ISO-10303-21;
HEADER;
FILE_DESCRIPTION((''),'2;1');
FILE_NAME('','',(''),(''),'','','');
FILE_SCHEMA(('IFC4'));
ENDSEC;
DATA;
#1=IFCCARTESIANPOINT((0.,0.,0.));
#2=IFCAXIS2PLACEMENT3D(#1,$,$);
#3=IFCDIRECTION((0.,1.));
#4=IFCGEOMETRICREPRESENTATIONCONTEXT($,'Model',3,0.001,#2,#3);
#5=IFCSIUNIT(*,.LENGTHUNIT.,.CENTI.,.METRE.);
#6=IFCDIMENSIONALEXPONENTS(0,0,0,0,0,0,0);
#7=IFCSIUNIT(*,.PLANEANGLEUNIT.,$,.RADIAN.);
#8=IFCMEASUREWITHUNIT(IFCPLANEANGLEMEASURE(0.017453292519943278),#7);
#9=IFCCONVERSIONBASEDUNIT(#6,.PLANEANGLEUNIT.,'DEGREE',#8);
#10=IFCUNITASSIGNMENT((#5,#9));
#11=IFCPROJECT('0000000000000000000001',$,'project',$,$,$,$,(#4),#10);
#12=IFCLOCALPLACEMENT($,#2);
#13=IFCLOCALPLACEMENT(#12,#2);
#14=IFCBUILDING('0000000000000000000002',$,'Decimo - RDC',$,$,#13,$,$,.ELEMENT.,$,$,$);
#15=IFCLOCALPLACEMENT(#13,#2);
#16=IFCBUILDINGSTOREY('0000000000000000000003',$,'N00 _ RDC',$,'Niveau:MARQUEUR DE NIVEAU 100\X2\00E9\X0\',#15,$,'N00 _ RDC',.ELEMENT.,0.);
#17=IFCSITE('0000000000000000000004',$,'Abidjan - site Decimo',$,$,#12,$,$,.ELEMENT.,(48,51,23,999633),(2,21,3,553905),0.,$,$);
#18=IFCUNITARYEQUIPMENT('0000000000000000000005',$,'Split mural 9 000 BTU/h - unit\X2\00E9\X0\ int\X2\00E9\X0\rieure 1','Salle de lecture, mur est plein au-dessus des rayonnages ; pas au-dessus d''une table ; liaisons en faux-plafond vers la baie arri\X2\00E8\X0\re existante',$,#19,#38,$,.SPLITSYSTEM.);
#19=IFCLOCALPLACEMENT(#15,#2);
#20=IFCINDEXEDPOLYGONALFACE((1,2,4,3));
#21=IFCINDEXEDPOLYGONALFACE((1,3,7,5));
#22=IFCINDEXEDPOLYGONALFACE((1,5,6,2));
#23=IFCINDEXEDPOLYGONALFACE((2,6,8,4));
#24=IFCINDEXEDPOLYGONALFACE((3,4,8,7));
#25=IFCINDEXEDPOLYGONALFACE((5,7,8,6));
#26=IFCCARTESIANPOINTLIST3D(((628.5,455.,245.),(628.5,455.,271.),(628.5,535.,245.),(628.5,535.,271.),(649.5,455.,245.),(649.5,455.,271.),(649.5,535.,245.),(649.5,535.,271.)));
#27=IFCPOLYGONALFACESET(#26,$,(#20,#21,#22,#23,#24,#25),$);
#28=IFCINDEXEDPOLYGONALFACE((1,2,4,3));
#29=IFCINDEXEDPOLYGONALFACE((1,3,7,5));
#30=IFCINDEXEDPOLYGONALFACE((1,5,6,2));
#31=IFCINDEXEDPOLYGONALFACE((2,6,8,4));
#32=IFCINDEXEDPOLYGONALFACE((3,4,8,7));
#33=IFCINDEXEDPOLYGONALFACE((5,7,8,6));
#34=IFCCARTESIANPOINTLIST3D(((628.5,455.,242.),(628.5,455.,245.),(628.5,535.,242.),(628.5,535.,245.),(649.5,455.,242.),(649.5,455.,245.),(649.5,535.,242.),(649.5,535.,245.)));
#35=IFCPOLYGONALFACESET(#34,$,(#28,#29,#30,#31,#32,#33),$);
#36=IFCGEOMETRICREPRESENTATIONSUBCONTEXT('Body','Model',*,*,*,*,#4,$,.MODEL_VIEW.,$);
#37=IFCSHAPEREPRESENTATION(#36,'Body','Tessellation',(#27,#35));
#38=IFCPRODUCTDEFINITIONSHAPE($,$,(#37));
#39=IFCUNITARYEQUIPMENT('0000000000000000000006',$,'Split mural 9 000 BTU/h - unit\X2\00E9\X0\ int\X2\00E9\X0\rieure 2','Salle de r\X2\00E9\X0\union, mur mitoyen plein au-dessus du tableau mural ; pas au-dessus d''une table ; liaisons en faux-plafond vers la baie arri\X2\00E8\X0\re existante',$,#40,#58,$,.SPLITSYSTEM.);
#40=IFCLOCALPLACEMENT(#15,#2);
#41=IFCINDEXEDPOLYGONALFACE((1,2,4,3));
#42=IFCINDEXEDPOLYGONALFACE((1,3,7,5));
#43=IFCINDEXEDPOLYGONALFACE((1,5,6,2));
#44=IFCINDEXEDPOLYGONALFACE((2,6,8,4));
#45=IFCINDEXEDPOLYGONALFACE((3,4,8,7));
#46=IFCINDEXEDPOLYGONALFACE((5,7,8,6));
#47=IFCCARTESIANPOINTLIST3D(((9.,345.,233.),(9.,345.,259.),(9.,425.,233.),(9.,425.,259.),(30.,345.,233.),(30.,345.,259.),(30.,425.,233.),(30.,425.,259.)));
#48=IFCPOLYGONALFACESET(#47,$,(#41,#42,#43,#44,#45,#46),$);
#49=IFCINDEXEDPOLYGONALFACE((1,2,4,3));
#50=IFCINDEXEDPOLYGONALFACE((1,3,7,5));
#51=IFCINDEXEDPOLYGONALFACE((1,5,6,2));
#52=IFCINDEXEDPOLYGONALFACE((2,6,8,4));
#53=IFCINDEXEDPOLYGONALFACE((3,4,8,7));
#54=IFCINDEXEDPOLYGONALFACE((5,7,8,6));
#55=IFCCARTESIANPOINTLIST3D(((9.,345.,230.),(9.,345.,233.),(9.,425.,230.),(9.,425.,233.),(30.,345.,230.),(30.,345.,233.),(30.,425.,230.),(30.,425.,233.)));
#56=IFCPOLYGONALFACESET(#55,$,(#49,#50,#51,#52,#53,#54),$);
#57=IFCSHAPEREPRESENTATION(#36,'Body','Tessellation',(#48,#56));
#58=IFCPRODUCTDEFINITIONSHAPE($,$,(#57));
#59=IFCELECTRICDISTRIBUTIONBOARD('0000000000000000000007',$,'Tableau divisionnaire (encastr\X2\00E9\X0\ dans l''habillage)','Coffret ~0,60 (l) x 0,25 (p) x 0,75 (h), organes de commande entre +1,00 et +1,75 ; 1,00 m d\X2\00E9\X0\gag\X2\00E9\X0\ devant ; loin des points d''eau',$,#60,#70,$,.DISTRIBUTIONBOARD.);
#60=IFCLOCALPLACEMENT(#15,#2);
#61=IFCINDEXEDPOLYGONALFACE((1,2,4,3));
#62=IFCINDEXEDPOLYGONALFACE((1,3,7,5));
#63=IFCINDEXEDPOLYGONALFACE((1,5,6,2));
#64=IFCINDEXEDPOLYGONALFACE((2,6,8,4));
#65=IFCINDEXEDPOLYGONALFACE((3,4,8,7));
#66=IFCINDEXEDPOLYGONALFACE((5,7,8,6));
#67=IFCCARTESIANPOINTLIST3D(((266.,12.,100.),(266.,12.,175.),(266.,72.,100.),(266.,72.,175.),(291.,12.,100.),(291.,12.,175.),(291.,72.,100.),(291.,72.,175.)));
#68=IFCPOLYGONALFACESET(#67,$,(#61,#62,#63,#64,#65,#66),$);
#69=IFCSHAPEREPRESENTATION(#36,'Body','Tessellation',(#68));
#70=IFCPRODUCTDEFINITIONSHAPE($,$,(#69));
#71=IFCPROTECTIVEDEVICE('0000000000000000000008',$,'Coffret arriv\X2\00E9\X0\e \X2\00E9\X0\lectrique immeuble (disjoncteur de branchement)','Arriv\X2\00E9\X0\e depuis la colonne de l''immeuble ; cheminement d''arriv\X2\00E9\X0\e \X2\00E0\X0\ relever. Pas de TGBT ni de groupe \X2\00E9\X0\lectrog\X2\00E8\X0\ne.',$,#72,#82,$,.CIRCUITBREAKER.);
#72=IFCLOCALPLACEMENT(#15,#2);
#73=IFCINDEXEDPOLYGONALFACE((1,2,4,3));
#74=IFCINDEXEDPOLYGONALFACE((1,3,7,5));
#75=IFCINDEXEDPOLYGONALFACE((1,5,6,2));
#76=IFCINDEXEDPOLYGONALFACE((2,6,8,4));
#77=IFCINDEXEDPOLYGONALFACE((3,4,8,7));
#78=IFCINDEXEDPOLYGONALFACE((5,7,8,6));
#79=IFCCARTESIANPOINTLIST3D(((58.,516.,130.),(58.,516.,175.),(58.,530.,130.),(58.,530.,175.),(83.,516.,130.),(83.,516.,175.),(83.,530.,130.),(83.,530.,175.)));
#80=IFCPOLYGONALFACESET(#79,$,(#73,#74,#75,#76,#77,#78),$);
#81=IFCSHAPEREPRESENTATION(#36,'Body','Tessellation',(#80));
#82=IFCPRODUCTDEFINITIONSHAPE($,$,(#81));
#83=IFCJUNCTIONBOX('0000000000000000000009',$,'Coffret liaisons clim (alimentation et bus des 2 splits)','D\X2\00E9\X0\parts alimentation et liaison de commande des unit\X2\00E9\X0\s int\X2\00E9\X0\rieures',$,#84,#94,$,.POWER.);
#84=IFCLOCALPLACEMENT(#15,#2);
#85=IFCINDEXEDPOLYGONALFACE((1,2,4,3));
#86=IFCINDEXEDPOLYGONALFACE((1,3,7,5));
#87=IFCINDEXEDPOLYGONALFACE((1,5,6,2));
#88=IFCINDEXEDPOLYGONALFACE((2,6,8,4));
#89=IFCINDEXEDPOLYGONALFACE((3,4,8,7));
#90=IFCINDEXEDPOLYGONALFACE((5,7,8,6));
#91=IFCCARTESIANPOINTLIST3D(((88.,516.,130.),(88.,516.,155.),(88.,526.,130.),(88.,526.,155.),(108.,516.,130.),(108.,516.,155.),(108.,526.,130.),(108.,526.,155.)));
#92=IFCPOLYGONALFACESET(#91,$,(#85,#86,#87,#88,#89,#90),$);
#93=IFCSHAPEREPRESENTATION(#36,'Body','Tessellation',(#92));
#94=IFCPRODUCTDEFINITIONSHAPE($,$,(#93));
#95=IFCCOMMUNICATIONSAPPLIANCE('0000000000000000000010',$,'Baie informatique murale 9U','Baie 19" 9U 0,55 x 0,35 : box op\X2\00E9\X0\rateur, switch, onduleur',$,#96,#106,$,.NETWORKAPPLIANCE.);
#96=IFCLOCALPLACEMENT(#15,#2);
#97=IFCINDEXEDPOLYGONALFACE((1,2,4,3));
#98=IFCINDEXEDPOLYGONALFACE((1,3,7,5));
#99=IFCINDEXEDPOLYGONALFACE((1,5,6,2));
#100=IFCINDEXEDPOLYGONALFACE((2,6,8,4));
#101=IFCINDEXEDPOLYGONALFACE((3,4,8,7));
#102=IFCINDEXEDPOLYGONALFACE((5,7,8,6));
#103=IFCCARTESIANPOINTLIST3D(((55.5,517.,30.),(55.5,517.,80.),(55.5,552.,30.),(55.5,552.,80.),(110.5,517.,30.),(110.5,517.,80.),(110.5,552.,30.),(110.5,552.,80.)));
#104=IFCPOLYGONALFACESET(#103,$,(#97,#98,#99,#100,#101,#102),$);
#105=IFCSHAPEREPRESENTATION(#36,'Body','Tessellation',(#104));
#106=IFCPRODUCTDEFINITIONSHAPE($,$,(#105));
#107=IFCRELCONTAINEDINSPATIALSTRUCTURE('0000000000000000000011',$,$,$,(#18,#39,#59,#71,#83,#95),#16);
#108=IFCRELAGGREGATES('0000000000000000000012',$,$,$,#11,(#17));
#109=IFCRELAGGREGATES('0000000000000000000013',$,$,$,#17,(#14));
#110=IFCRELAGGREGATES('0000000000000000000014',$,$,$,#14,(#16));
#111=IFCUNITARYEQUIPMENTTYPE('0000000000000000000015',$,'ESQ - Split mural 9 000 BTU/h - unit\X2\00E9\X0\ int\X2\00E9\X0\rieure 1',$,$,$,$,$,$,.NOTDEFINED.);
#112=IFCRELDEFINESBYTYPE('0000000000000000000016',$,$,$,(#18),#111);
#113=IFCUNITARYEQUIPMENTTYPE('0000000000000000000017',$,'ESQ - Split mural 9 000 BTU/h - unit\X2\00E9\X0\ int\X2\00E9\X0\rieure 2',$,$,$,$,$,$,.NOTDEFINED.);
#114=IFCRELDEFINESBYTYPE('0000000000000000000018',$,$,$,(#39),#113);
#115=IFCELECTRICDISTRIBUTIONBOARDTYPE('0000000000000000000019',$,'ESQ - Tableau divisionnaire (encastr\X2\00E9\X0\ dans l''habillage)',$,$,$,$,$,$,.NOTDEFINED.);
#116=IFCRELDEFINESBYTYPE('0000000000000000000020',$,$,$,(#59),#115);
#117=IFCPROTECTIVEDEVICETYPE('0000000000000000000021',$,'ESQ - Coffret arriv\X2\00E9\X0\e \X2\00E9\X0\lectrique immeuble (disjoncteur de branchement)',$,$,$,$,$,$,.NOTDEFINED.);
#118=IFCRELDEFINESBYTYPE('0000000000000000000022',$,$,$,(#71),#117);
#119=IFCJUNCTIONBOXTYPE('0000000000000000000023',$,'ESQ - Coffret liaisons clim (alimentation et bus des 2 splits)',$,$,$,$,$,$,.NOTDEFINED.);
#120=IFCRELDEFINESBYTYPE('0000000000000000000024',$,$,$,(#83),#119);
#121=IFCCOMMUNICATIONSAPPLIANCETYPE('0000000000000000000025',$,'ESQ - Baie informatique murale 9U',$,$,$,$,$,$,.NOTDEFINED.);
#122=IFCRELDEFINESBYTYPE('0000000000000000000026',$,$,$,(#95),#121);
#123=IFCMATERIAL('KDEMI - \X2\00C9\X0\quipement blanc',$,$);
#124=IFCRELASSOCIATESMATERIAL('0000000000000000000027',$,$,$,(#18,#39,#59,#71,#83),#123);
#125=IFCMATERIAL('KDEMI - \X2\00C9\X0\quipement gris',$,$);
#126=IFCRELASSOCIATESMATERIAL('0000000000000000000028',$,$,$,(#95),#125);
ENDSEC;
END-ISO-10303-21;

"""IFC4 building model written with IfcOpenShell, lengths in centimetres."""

from ifc_helpers import new_model, entity, si_unit, converted_unit, direction, frame, frame_2d, origin, origin_with_axes, place, context, subcontext, project, spatial, rectangle, extrude, material, type_object, element, save


model = new_model("IFC4")

# Units and contexts
model_context = context("Model", 3, precision=0.001, world=origin(), true_north=direction((0.0, 1.0)))
body_context = subcontext(model_context, "Body", "Model", "MODEL_VIEW")
ifc_project = project(units=[si_unit("LENGTHUNIT", "METRE", prefix="CENTI"), converted_unit("PLANEANGLEUNIT", "DEGREE", entity("IfcPlaneAngleMeasure", 0.017453292519943278), si_unit("PLANEANGLEUNIT", "RADIAN"), dimensions=[0, 0, 0, 0, 0, 0, 0])], contexts=[model_context])

# Site, building, storey
site_placement = place(None, origin())
site = spatial("IfcSite", under=ifc_project, at=site_placement, Name="Abidjan - site Decimo", CompositionType="ELEMENT", RefLatitude=(48, 51, 23, 999633), RefLongitude=(2, 21, 3, 553905), RefElevation=0.0)
building_placement = place(site_placement, origin())
building = spatial("IfcBuilding", under=site, at=building_placement, Name="Decimo - RDC", CompositionType="ELEMENT")
storey_placement = place(building_placement, origin())
storey = spatial("IfcBuildingStorey", under=building, at=storey_placement, Name="N00 _ RDC", ObjectType="Niveau:MARQUEUR DE NIVEAU 100é", LongName="N00 _ RDC", CompositionType="ELEMENT", Elevation=0.0)

# Shared definitions
ifc_material_1 = material(Name="KDEMI - Équipement blanc")

# Unitary equipment
unitary_equipment_type_1 = type_object("IfcUnitaryEquipmentType", Name="ESQ - Split mural 9 000 BTU/h - unité intérieure 1", PredefinedType="NOTDEFINED")
unitary_equipment_1_placement = place(storey_placement, origin_with_axes())
element("IfcUnitaryEquipment", 1, at=unitary_equipment_1_placement, inside=storey, type_object=unitary_equipment_type_1, material=ifc_material_1, Name="Split mural 9 000 BTU/h - unité intérieure 1", Description="Salle de lecture, mur est plein au-dessus des rayonnages ; pas au-dessus d'une table ; liaisons en faux-plafond vers la baie arrière existante", PredefinedType="SPLITSYSTEM", context=body_context, shape_type="SweptSolid", body=[
    extrude(rectangle(XDim=21.0, YDim=80.0, at=frame_2d((639.0, 495.0))), frame((0.0, 0.0, 245.0)), (0.0, 0.0, 1.0), 26.0),
    extrude(rectangle(XDim=21.0, YDim=80.0, at=frame_2d((639.0, 495.0))), frame((0.0, 0.0, 242.0)), (0.0, 0.0, 1.0), 3.0),
])
unitary_equipment_type_2 = type_object("IfcUnitaryEquipmentType", Name="ESQ - Split mural 9 000 BTU/h - unité intérieure 2", PredefinedType="NOTDEFINED")
unitary_equipment_2_placement = place(storey_placement, origin_with_axes())
element("IfcUnitaryEquipment", 2, at=unitary_equipment_2_placement, inside=storey, type_object=unitary_equipment_type_2, material=ifc_material_1, Name="Split mural 9 000 BTU/h - unité intérieure 2", Description="Salle de réunion, mur mitoyen plein au-dessus du tableau mural ; pas au-dessus d'une table ; liaisons en faux-plafond vers la baie arrière existante", PredefinedType="SPLITSYSTEM", context=body_context, shape_type="SweptSolid", body=[
    extrude(rectangle(XDim=21.0, YDim=80.0, at=frame_2d((19.5, 385.0))), frame((0.0, 0.0, 233.0)), (0.0, 0.0, 1.0), 26.0),
    extrude(rectangle(XDim=21.0, YDim=80.0, at=frame_2d((19.5, 385.0))), frame((0.0, 0.0, 230.0)), (0.0, 0.0, 1.0), 3.0),
])

# Electric distribution board
electric_distribution_board_type = type_object("IfcElectricDistributionBoardType", Name="ESQ - Tableau divisionnaire (encastré dans l'habillage)", PredefinedType="NOTDEFINED")
electric_distribution_board_placement = place(storey_placement, origin_with_axes())
element("IfcElectricDistributionBoard", 3, at=electric_distribution_board_placement, inside=storey, type_object=electric_distribution_board_type, material=ifc_material_1, Name="Tableau divisionnaire (encastré dans l'habillage)", Description="Coffret ~0,60 (l) x 0,25 (p) x 0,75 (h), organes de commande entre +1,00 et +1,75 ; 1,00 m dégagé devant ; loin des points d'eau", PredefinedType="DISTRIBUTIONBOARD", context=body_context, shape_type="SweptSolid", body=[
    extrude(rectangle(XDim=25.0, YDim=60.0, at=frame_2d((278.5, 42.0))), frame((0.0, 0.0, 100.0)), (0.0, 0.0, 1.0), 75.0),
])

# Protective device
protective_device_type = type_object("IfcProtectiveDeviceType", Name="ESQ - Coffret arrivée électrique immeuble (disjoncteur de branchement)", PredefinedType="NOTDEFINED")
protective_device_placement = place(storey_placement, origin_with_axes())
element("IfcProtectiveDevice", 4, at=protective_device_placement, inside=storey, type_object=protective_device_type, material=ifc_material_1, Name="Coffret arrivée électrique immeuble (disjoncteur de branchement)", Description="Arrivée depuis la colonne de l'immeuble ; cheminement d'arrivée à relever. Pas de TGBT ni de groupe électrogène.", PredefinedType="CIRCUITBREAKER", context=body_context, shape_type="SweptSolid", body=[
    extrude(rectangle(XDim=25.0, YDim=14.0, at=frame_2d((70.5, 523.0))), frame((0.0, 0.0, 130.0)), (0.0, 0.0, 1.0), 45.0),
])

# Junction box
junction_box_type = type_object("IfcJunctionBoxType", Name="ESQ - Coffret liaisons clim (alimentation et bus des 2 splits)", PredefinedType="NOTDEFINED")
junction_box_placement = place(storey_placement, origin_with_axes())
element("IfcJunctionBox", 5, at=junction_box_placement, inside=storey, type_object=junction_box_type, material=ifc_material_1, Name="Coffret liaisons clim (alimentation et bus des 2 splits)", Description="Départs alimentation et liaison de commande des unités intérieures", PredefinedType="POWER", context=body_context, shape_type="SweptSolid", body=[
    extrude(rectangle(XDim=20.0, YDim=10.0, at=frame_2d((98.0, 521.0))), frame((0.0, 0.0, 130.0)), (0.0, 0.0, 1.0), 25.0),
])

# Communications appliance
ifc_material_2 = material(Name="KDEMI - Équipement gris")
communications_appliance_type = type_object("IfcCommunicationsApplianceType", Name="ESQ - Baie informatique murale 9U", PredefinedType="NOTDEFINED")
communications_appliance_placement = place(storey_placement, origin_with_axes())
element("IfcCommunicationsAppliance", 6, at=communications_appliance_placement, inside=storey, type_object=communications_appliance_type, material=ifc_material_2, Name="Baie informatique murale 9U", Description="Baie 19\" 9U 0,55 x 0,35 : box opérateur, switch, onduleur", PredefinedType="NETWORKAPPLIANCE", context=body_context, shape_type="SweptSolid", body=[
    extrude(rectangle(XDim=55.0, YDim=35.0, at=frame_2d((83.0, 534.5))), frame((0.0, 0.0, 30.0)), (0.0, 0.0, 1.0), 50.0),
])

save(model, "model.ifc")
